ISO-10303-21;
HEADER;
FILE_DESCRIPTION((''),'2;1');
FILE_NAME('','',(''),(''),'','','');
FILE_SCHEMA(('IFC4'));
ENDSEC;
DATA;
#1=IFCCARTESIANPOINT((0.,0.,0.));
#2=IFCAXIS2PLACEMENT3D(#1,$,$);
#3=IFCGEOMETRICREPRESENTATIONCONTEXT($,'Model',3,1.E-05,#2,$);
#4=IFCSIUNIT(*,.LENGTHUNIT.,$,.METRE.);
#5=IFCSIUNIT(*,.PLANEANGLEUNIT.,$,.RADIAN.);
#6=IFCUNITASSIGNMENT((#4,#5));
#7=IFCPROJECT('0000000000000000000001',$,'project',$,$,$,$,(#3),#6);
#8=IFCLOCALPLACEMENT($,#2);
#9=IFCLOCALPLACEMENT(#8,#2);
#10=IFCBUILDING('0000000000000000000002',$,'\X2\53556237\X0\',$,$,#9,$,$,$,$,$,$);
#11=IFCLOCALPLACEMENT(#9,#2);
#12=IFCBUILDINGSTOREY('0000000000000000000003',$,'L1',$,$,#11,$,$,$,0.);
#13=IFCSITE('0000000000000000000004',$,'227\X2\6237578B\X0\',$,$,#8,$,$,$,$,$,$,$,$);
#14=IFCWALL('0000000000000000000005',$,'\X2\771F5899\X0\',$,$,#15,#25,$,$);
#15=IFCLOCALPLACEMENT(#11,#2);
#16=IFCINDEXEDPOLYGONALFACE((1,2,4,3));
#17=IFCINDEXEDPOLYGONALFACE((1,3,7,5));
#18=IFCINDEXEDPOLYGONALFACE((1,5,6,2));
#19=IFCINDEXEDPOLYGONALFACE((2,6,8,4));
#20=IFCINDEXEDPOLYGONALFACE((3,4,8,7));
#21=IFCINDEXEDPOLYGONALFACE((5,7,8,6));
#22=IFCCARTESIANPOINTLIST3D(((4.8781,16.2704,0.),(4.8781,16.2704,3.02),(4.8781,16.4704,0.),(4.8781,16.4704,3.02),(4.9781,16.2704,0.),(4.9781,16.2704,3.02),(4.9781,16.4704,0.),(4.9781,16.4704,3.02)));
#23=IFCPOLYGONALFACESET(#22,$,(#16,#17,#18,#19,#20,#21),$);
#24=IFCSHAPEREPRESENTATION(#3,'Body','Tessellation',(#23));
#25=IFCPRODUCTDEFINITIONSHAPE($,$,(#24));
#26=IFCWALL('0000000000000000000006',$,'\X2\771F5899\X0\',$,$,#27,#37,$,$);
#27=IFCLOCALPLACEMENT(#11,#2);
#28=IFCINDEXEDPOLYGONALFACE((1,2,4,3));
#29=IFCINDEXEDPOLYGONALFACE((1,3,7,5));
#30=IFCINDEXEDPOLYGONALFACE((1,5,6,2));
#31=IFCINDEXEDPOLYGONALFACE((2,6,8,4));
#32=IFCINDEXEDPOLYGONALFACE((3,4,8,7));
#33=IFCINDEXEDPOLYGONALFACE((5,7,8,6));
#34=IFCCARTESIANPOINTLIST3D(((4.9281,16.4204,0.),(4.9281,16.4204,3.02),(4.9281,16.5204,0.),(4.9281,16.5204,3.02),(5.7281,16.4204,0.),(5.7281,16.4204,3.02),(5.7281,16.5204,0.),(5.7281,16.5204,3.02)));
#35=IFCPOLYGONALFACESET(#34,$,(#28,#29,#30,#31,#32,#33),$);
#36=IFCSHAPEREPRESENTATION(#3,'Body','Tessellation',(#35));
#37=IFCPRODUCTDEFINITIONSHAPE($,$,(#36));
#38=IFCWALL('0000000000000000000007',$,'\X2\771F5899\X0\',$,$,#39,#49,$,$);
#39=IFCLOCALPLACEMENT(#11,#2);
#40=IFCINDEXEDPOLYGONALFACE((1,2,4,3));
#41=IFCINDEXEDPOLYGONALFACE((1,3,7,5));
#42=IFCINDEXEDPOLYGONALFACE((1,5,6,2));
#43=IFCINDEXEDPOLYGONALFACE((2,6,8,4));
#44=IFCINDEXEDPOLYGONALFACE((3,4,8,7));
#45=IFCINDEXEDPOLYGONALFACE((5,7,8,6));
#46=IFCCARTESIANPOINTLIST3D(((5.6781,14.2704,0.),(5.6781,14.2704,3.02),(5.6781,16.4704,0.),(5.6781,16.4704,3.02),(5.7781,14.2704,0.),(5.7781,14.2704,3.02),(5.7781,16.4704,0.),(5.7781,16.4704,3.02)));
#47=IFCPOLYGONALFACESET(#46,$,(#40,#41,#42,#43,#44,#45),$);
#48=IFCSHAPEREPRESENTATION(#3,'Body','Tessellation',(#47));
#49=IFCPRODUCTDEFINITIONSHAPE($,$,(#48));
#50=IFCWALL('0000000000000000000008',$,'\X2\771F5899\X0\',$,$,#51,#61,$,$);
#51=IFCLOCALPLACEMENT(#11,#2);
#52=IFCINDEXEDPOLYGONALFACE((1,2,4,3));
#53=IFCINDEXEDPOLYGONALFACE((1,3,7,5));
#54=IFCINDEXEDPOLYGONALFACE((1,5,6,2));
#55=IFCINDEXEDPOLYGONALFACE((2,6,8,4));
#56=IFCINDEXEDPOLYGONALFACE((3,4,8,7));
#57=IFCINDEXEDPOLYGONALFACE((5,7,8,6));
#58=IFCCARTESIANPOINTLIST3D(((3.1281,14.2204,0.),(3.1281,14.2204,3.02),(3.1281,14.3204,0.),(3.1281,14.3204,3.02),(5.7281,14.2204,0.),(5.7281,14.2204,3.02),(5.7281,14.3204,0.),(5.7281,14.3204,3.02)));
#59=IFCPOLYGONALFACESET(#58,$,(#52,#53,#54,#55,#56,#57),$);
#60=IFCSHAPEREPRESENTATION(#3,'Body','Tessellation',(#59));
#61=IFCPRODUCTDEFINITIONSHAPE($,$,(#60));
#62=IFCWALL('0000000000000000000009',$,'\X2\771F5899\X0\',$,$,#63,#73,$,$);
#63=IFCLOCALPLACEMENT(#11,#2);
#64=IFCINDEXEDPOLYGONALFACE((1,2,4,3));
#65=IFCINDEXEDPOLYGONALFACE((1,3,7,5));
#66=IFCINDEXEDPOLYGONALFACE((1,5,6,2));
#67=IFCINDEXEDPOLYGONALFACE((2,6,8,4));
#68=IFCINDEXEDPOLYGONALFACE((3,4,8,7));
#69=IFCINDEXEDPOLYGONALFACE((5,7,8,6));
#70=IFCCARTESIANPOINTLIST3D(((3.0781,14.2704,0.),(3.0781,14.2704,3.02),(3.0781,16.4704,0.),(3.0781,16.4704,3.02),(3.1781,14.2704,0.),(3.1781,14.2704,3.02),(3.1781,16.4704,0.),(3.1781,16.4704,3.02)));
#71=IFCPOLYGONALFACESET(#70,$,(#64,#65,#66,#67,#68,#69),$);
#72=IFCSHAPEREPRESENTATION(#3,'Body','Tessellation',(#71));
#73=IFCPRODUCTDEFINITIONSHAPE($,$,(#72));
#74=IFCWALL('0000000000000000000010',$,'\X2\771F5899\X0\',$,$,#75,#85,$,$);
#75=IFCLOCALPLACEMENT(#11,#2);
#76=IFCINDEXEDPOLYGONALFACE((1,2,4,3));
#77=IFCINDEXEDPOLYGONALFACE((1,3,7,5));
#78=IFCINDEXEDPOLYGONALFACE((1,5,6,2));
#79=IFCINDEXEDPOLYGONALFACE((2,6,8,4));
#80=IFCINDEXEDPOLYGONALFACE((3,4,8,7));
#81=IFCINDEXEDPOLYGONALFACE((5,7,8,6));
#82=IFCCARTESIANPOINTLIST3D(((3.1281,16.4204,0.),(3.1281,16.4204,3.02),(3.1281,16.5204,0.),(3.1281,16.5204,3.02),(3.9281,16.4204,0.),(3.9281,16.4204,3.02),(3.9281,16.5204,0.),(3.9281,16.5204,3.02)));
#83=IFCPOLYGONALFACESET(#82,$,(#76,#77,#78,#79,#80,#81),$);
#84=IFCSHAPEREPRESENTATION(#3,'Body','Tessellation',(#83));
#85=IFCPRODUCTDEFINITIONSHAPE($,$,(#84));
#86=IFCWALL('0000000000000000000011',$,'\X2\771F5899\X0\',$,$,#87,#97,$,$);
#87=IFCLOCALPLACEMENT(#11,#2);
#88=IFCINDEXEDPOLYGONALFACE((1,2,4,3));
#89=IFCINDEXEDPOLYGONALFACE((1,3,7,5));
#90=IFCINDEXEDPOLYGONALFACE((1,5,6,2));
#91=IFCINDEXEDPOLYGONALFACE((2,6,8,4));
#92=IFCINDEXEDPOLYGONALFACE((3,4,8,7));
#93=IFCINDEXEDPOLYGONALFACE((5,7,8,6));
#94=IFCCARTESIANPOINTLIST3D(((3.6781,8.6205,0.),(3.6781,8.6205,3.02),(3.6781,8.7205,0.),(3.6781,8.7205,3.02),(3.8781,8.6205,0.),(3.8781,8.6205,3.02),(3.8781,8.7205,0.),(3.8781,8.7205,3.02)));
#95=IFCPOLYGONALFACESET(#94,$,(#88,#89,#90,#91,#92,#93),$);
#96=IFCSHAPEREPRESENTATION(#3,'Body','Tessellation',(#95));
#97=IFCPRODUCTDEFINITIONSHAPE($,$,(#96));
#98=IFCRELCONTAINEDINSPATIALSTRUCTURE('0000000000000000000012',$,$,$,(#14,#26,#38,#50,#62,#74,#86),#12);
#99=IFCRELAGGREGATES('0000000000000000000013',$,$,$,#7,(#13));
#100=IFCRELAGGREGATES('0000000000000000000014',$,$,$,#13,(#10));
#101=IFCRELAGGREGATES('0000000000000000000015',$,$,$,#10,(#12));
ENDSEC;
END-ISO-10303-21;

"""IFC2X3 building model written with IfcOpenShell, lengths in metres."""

from ifc_helpers import new_model, si_unit, origin, place, context, project, spatial, polyline, outline, extrude, element, save


model = new_model("IFC2X3")

# Units and contexts
model_context = context("Model", 3, precision=1e-05, world=origin())
ifc_project = project(units=[si_unit("LENGTHUNIT", "METRE"), si_unit("PLANEANGLEUNIT", "RADIAN")], contexts=[model_context])

# Site, building, storey
site_placement = place(None, origin())
site = spatial("IfcSite", under=ifc_project, at=site_placement, Name="227户型")
building_placement = place(site_placement, origin())
building = spatial("IfcBuilding", under=site, at=building_placement, Name="单户")
storey_placement = place(building_placement, origin())
storey = spatial("IfcBuildingStorey", under=building, at=storey_placement, Name="L1", Elevation=0.0)

# Walls
wall_1_placement = place(storey_placement, origin())
element("IfcWall", 1, at=wall_1_placement, inside=storey, Name="真墙", context=model_context, shape_type="SweptSolid", body=[
    extrude(outline(polyline([(4.8781, 16.2704), (4.8781, 16.4704), (4.9781, 16.4704), (4.9781, 16.2704), (4.8781, 16.2704)])), origin(), (0.0, 0.0, 1.0), 3.02),
])
wall_2_placement = place(storey_placement, origin())
element("IfcWall", 2, at=wall_2_placement, inside=storey, Name="真墙", context=model_context, shape_type="SweptSolid", body=[
    extrude(outline(polyline([(4.9281, 16.5204), (5.7281, 16.5204), (5.7281, 16.4204), (4.9281, 16.4204), (4.9281, 16.5204)])), origin(), (0.0, 0.0, 1.0), 3.02),
])
wall_3_placement = place(storey_placement, origin())
element("IfcWall", 3, at=wall_3_placement, inside=storey, Name="真墙", context=model_context, shape_type="SweptSolid", body=[
    extrude(outline(polyline([(5.7781, 16.4704), (5.7781, 14.2704), (5.6781, 14.2704), (5.6781, 16.4704), (5.7781, 16.4704)])), origin(), (0.0, 0.0, 1.0), 3.02),
])
wall_4_placement = place(storey_placement, origin())
element("IfcWall", 4, at=wall_4_placement, inside=storey, Name="真墙", context=model_context, shape_type="SweptSolid", body=[
    extrude(outline(polyline([(5.7281, 14.2204), (3.1281, 14.2204), (3.1281, 14.3204), (5.7281, 14.3204), (5.7281, 14.2204)])), origin(), (0.0, 0.0, 1.0), 3.02),
])
wall_5_placement = place(storey_placement, origin())
element("IfcWall", 5, at=wall_5_placement, inside=storey, Name="真墙", context=model_context, shape_type="SweptSolid", body=[
    extrude(outline(polyline([(3.0781, 14.2704), (3.0781, 16.4704), (3.1781, 16.4704), (3.1781, 14.2704), (3.0781, 14.2704)])), origin(), (0.0, 0.0, 1.0), 3.02),
])
wall_6_placement = place(storey_placement, origin())
element("IfcWall", 6, at=wall_6_placement, inside=storey, Name="真墙", context=model_context, shape_type="SweptSolid", body=[
    extrude(outline(polyline([(3.1281, 16.5204), (3.9281, 16.5204), (3.9281, 16.4204), (3.1281, 16.4204), (3.1281, 16.5204)])), origin(), (0.0, 0.0, 1.0), 3.02),
])
wall_7_placement = place(storey_placement, origin())
element("IfcWall", 7, at=wall_7_placement, inside=storey, Name="真墙", context=model_context, shape_type="SweptSolid", body=[
    extrude(outline(polyline([(3.6781, 8.7205), (3.8781, 8.7205), (3.8781, 8.6205), (3.6781, 8.6205), (3.6781, 8.7205)])), origin(), (0.0, 0.0, 1.0), 3.02),
])

save(model, "model.ifc")
